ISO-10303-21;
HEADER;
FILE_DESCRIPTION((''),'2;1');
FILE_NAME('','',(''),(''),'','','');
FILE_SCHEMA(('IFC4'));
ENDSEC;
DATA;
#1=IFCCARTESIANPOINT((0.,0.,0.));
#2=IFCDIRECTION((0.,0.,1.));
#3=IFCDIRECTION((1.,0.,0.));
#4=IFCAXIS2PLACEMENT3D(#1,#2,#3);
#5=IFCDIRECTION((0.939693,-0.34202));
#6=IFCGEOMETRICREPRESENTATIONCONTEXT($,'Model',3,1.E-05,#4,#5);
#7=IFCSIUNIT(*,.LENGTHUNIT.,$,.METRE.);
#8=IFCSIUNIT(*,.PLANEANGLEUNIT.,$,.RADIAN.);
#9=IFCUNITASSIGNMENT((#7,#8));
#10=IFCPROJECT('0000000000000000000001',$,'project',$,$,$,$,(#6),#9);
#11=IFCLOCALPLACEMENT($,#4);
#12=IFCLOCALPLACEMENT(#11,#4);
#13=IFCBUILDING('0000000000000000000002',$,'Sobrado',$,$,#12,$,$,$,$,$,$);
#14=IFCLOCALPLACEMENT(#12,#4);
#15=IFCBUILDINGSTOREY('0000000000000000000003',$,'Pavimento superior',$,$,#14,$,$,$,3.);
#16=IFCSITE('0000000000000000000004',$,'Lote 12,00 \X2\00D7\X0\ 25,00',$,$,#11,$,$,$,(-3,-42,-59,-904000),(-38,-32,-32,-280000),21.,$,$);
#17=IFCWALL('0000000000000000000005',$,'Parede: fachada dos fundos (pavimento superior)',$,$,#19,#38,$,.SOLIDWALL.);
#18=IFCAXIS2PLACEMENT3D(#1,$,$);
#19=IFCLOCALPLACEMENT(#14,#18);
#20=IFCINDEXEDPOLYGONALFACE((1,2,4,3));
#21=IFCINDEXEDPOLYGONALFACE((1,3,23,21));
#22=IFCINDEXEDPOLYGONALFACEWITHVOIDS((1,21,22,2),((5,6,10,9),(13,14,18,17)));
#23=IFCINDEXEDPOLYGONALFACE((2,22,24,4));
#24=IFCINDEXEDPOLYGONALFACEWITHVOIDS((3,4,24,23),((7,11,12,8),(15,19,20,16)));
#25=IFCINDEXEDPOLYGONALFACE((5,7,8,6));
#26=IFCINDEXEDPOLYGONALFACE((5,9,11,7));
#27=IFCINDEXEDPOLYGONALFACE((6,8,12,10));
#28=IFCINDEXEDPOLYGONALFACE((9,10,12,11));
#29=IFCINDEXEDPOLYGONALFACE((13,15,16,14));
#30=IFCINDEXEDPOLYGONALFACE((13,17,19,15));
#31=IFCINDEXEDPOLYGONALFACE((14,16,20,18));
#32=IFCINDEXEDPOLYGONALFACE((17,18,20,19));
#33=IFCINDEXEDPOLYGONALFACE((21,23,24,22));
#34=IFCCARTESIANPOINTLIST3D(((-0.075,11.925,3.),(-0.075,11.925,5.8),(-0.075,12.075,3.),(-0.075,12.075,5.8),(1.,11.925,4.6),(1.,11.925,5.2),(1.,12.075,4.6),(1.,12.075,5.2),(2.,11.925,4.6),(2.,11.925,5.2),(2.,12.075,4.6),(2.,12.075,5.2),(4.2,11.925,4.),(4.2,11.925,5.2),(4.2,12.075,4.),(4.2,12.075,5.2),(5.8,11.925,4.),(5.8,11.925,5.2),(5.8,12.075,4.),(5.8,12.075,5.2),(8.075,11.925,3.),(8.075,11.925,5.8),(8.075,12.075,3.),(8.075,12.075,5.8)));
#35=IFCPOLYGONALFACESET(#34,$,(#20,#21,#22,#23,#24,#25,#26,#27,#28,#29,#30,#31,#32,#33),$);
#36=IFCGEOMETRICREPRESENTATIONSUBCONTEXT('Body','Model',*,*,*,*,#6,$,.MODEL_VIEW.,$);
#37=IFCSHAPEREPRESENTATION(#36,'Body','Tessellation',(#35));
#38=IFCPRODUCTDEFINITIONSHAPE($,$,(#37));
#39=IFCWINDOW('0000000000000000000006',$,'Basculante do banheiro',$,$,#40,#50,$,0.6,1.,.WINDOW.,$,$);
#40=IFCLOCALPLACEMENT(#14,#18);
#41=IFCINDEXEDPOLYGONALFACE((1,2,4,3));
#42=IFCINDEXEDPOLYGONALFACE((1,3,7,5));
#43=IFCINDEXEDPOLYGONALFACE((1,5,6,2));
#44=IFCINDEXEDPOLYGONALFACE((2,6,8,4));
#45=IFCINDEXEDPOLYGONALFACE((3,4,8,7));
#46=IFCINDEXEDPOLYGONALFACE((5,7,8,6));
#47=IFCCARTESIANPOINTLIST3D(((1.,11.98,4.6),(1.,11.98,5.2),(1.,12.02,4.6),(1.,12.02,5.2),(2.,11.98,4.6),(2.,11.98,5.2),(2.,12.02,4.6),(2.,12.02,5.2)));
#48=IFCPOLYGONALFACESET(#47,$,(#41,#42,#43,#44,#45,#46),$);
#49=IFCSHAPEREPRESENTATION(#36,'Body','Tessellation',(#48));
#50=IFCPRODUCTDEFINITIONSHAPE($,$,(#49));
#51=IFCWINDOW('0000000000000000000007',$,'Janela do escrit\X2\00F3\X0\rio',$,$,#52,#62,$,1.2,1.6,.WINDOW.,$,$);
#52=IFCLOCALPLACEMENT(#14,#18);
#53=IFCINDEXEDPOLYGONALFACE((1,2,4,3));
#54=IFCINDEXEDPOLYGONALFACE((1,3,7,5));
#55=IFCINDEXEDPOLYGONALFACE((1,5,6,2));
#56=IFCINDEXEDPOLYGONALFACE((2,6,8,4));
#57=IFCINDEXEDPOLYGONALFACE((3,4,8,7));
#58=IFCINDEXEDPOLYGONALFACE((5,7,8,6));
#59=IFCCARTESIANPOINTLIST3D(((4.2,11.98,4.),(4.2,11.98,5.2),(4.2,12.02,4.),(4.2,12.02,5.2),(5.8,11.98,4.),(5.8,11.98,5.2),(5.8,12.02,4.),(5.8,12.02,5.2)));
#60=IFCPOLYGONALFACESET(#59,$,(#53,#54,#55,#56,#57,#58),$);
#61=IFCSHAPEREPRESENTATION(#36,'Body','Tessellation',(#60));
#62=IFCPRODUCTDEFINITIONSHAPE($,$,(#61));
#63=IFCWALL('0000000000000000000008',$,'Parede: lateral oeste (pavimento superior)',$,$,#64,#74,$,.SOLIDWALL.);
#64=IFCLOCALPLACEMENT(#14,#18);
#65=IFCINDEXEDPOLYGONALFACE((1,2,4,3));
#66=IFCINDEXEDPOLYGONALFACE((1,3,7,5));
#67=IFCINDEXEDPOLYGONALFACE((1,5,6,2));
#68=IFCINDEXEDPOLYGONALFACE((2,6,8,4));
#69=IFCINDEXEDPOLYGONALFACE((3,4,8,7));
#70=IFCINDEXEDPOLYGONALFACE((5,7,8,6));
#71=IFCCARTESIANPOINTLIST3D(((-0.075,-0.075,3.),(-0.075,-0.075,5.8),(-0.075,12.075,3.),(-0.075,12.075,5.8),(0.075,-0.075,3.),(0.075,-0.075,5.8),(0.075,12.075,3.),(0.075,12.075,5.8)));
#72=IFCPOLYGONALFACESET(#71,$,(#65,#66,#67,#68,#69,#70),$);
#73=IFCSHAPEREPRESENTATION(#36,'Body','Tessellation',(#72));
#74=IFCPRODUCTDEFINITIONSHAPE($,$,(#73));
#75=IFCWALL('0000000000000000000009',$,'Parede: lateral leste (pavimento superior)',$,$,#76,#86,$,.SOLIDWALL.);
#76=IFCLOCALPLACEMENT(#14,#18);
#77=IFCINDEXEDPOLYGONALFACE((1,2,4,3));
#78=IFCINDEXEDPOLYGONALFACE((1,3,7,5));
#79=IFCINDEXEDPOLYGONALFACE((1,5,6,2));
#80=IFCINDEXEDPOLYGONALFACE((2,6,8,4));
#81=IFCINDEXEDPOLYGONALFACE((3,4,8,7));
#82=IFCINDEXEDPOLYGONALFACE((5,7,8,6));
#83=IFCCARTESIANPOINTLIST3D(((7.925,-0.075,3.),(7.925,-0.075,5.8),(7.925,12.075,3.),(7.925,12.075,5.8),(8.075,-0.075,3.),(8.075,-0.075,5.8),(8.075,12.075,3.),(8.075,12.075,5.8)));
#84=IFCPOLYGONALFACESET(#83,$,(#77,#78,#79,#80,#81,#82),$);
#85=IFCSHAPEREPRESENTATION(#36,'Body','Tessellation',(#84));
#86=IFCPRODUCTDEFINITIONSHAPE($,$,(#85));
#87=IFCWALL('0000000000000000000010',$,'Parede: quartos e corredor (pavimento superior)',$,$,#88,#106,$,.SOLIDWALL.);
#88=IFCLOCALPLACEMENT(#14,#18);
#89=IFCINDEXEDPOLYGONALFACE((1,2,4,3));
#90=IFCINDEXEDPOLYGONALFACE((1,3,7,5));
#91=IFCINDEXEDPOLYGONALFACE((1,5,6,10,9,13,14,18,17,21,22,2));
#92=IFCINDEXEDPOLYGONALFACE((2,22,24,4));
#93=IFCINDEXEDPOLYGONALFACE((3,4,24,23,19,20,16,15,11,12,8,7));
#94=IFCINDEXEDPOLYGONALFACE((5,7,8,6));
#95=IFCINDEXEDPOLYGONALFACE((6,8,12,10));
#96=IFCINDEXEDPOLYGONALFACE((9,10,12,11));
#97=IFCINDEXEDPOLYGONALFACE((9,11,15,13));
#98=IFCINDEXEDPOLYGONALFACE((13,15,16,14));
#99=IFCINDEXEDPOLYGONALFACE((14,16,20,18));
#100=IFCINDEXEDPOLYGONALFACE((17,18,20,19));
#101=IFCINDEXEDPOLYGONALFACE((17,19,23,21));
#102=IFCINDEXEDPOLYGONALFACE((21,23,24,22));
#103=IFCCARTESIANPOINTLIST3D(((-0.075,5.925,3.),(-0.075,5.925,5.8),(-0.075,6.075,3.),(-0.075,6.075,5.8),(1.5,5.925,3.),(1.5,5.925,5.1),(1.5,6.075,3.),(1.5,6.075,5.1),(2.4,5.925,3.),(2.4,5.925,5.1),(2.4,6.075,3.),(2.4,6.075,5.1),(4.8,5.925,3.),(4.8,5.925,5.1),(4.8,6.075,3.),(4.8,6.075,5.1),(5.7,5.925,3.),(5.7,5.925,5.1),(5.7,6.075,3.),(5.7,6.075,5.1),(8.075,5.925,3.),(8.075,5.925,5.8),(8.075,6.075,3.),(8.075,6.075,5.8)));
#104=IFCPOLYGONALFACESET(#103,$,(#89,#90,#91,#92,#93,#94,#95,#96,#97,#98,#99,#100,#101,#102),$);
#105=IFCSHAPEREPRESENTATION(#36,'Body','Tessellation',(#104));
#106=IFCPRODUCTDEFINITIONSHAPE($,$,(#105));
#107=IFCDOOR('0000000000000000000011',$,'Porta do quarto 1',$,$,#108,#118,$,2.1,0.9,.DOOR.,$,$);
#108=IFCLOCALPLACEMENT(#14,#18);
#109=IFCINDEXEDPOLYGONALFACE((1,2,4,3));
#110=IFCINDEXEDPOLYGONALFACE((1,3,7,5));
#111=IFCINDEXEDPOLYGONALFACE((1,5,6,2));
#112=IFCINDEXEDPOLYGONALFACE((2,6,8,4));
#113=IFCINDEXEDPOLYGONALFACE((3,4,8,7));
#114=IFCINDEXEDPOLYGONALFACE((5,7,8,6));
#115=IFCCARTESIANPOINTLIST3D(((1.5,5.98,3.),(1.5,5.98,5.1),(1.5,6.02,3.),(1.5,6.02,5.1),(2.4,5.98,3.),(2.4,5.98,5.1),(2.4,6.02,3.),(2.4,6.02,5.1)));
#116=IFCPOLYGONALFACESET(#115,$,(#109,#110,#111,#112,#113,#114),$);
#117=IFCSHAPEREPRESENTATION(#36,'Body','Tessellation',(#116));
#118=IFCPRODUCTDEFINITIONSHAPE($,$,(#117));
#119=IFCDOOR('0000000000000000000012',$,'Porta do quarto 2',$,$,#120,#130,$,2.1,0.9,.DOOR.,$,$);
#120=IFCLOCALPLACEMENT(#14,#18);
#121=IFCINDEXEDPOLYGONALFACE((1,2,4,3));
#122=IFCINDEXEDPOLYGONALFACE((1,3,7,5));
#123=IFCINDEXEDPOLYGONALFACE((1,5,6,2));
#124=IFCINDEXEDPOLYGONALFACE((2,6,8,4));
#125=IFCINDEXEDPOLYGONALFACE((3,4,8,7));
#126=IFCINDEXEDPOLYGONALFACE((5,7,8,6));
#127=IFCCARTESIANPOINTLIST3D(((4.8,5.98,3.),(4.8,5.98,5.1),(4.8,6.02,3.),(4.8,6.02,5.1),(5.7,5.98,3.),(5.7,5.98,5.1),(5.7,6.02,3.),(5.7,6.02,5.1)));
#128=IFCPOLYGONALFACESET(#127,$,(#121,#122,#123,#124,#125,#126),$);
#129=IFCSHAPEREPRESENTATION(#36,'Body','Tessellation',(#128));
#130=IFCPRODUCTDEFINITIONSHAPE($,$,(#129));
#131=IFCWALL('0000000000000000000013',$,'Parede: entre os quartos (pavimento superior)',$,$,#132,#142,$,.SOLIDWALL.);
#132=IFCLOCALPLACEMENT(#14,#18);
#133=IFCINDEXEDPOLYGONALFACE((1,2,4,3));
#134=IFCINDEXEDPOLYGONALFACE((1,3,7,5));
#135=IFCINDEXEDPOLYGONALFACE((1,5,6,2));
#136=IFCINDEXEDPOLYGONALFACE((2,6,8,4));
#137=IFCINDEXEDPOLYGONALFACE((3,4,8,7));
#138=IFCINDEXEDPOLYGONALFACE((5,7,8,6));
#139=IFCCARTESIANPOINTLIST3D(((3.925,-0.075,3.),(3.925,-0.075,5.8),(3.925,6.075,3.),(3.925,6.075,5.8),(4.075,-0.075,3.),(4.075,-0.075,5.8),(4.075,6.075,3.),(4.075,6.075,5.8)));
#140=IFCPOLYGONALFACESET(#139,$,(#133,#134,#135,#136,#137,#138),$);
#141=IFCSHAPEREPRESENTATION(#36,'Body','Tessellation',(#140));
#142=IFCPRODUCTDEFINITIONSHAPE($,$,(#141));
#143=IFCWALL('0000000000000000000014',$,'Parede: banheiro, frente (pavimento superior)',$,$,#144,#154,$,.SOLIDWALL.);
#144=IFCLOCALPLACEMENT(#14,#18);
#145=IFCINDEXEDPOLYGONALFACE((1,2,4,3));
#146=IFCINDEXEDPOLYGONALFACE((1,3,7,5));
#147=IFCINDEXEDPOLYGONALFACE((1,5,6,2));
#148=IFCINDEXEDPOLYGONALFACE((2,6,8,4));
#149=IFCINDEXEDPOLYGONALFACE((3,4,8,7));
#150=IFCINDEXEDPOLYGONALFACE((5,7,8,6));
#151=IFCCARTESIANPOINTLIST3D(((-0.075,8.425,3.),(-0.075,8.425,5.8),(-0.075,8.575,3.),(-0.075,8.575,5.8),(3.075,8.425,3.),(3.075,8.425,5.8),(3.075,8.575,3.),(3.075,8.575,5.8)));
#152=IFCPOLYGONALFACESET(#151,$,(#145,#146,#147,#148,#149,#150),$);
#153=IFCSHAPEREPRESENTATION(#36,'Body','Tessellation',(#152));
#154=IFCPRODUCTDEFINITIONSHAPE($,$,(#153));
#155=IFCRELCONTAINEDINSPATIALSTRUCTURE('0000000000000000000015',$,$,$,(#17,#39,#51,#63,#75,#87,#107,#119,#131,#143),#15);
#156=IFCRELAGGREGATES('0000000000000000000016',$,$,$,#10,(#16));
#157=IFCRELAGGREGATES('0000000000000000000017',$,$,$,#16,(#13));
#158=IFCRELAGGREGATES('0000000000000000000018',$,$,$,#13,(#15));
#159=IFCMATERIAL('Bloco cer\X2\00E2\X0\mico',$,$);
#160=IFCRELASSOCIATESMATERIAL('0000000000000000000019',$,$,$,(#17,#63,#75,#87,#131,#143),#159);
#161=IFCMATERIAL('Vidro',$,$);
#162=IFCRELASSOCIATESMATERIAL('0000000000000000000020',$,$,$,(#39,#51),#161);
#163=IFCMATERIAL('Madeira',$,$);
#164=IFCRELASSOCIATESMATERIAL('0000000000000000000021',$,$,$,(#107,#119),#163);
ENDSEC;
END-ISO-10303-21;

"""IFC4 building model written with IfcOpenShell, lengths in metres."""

from ifc_helpers import new_model, si_unit, direction, frame, origin_with_axes, place, context, subcontext, project, spatial, line, indexed_curve, outline, extrude, material, element, fill, save


model = new_model("IFC4")

# Units and contexts
model_context = context("Model", 3, precision=1e-05, world=origin_with_axes(), true_north=direction((0.939693, -0.34202)))
body_context = subcontext(model_context, "Body", "Model", "MODEL_VIEW")
ifc_project = project(units=[si_unit("LENGTHUNIT", "METRE"), si_unit("PLANEANGLEUNIT", "RADIAN")], contexts=[model_context])

# Site, building, storey
site_placement = place(None, origin_with_axes())
site = spatial("IfcSite", under=ifc_project, at=site_placement, Name="Lote 12,00 × 25,00", RefLatitude=(-3, -42, -59, -904000), RefLongitude=(-38, -32, -32, -280000), RefElevation=21.0)
building_placement = place(site_placement, origin_with_axes())
building = spatial("IfcBuilding", under=site, at=building_placement, Name="Sobrado")
storey_placement = place(building_placement, origin_with_axes())
storey = spatial("IfcBuildingStorey", under=building, at=storey_placement, Name="Pavimento superior", Elevation=3.0)

# Shared definitions
ifc_material_1 = material(Name="Concreto armado")

# Wall, openings, windows
ifc_material_2 = material(Name="Bloco cerâmico")
ifc_material_3 = material(Name="Vidro")
wall_1_placement = place(storey_placement, origin_with_axes())
wall_1 = element("IfcWall", 1, at=wall_1_placement, inside=storey, material=ifc_material_2, Name="Parede: fachada dos fundos (pavimento superior)", PredefinedType="SOLIDWALL", context=body_context, shape_type="SweptSolid", body=[
    extrude(outline(indexed_curve([(-0.075, 11.925), (8.075, 11.925), (8.075, 12.075), (-0.075, 12.075)], segments=[line(1, 2, 3, 4, 1)])), frame((0.0, 0.0, 3.0), z_axis=(0.0, 0.0, 1.0), x_axis=(1.0, 0.0, 0.0)), (0.0, 0.0, 1.0), 2.8),
])
opening_1_placement = place(wall_1_placement, origin_with_axes())
opening_1 = element("IfcOpeningElement", 2, at=opening_1_placement, cuts=wall_1, material=ifc_material_1, PredefinedType="OPENING", context=body_context, shape_type="SweptSolid", body=[
    extrude(outline(indexed_curve([(1.0, 11.875), (2.0, 11.875), (2.0, 12.125), (1.0, 12.125)], segments=[line(1, 2, 3, 4, 1)])), frame((0.0, 0.0, 4.6), z_axis=(0.0, 0.0, 1.0), x_axis=(1.0, 0.0, 0.0)), (0.0, 0.0, 1.0), 0.6),
])
opening_2_placement = place(wall_1_placement, origin_with_axes())
opening_2 = element("IfcOpeningElement", 3, at=opening_2_placement, cuts=wall_1, material=ifc_material_1, PredefinedType="OPENING", context=body_context, shape_type="SweptSolid", body=[
    extrude(outline(indexed_curve([(4.2, 11.875), (5.8, 11.875), (5.8, 12.125), (4.2, 12.125)], segments=[line(1, 2, 3, 4, 1)])), frame((0.0, 0.0, 4.0), z_axis=(0.0, 0.0, 1.0), x_axis=(1.0, 0.0, 0.0)), (0.0, 0.0, 1.0), 1.2),
])
window_1_placement = place(storey_placement, origin_with_axes())
window_1 = element("IfcWindow", 4, at=window_1_placement, inside=storey, material=ifc_material_3, Name="Basculante do banheiro", OverallHeight=0.6, OverallWidth=1.0, PredefinedType="WINDOW", context=body_context, shape_type="SweptSolid", body=[
    extrude(outline(indexed_curve([(1.0, 11.98), (2.0, 11.98), (2.0, 12.02), (1.0, 12.02)], segments=[line(1, 2, 3, 4, 1)])), frame((0.0, 0.0, 4.6), z_axis=(0.0, 0.0, 1.0), x_axis=(1.0, 0.0, 0.0)), (0.0, 0.0, 1.0), 0.6),
])
fill(opening_1, window_1)
window_2_placement = place(storey_placement, origin_with_axes())
window_2 = element("IfcWindow", 5, at=window_2_placement, inside=storey, material=ifc_material_3, Name="Janela do escritório", OverallHeight=1.2, OverallWidth=1.6, PredefinedType="WINDOW", context=body_context, shape_type="SweptSolid", body=[
    extrude(outline(indexed_curve([(4.2, 11.98), (5.8, 11.98), (5.8, 12.02), (4.2, 12.02)], segments=[line(1, 2, 3, 4, 1)])), frame((0.0, 0.0, 4.0), z_axis=(0.0, 0.0, 1.0), x_axis=(1.0, 0.0, 0.0)), (0.0, 0.0, 1.0), 1.2),
])
fill(opening_2, window_2)

# Walls
wall_2_placement = place(storey_placement, origin_with_axes())
element("IfcWall", 6, at=wall_2_placement, inside=storey, material=ifc_material_2, Name="Parede: lateral oeste (pavimento superior)", PredefinedType="SOLIDWALL", context=body_context, shape_type="SweptSolid", body=[
    extrude(outline(indexed_curve([(-0.075, -0.075), (0.075, -0.075), (0.075, 12.075), (-0.075, 12.075)], segments=[line(1, 2, 3, 4, 1)])), frame((0.0, 0.0, 3.0), z_axis=(0.0, 0.0, 1.0), x_axis=(1.0, 0.0, 0.0)), (0.0, 0.0, 1.0), 2.8),
])
wall_3_placement = place(storey_placement, origin_with_axes())
element("IfcWall", 7, at=wall_3_placement, inside=storey, material=ifc_material_2, Name="Parede: lateral leste (pavimento superior)", PredefinedType="SOLIDWALL", context=body_context, shape_type="SweptSolid", body=[
    extrude(outline(indexed_curve([(7.925, -0.075), (8.075, -0.075), (8.075, 12.075), (7.925, 12.075)], segments=[line(1, 2, 3, 4, 1)])), frame((0.0, 0.0, 3.0), z_axis=(0.0, 0.0, 1.0), x_axis=(1.0, 0.0, 0.0)), (0.0, 0.0, 1.0), 2.8),
])

# Wall, openings, doors
wall_4_placement = place(storey_placement, origin_with_axes())
wall_4 = element("IfcWall", 8, at=wall_4_placement, inside=storey, material=ifc_material_2, Name="Parede: quartos e corredor (pavimento superior)", PredefinedType="SOLIDWALL", context=body_context, shape_type="SweptSolid", body=[
    extrude(outline(indexed_curve([(-0.075, 5.925), (8.075, 5.925), (8.075, 6.075), (-0.075, 6.075)], segments=[line(1, 2, 3, 4, 1)])), frame((0.0, 0.0, 3.0), z_axis=(0.0, 0.0, 1.0), x_axis=(1.0, 0.0, 0.0)), (0.0, 0.0, 1.0), 2.8),
])
opening_3_placement = place(wall_4_placement, origin_with_axes())
opening_3 = element("IfcOpeningElement", 9, at=opening_3_placement, cuts=wall_4, material=ifc_material_1, PredefinedType="OPENING", context=body_context, shape_type="SweptSolid", body=[
    extrude(outline(indexed_curve([(1.5, 5.875), (2.4, 5.875), (2.4, 6.125), (1.5, 6.125)], segments=[line(1, 2, 3, 4, 1)])), frame((0.0, 0.0, 3.0), z_axis=(0.0, 0.0, 1.0), x_axis=(1.0, 0.0, 0.0)), (0.0, 0.0, 1.0), 2.1),
])
opening_4_placement = place(wall_4_placement, origin_with_axes())
opening_4 = element("IfcOpeningElement", 10, at=opening_4_placement, cuts=wall_4, material=ifc_material_1, PredefinedType="OPENING", context=body_context, shape_type="SweptSolid", body=[
    extrude(outline(indexed_curve([(4.8, 5.875), (5.7, 5.875), (5.7, 6.125), (4.8, 6.125)], segments=[line(1, 2, 3, 4, 1)])), frame((0.0, 0.0, 3.0), z_axis=(0.0, 0.0, 1.0), x_axis=(1.0, 0.0, 0.0)), (0.0, 0.0, 1.0), 2.1),
])
ifc_material_4 = material(Name="Madeira")
door_1_placement = place(storey_placement, origin_with_axes())
door_1 = element("IfcDoor", 11, at=door_1_placement, inside=storey, material=ifc_material_4, Name="Porta do quarto 1", OverallHeight=2.1, OverallWidth=0.9, PredefinedType="DOOR", context=body_context, shape_type="SweptSolid", body=[
    extrude(outline(indexed_curve([(1.5, 5.98), (2.4, 5.98), (2.4, 6.02), (1.5, 6.02)], segments=[line(1, 2, 3, 4, 1)])), frame((0.0, 0.0, 3.0), z_axis=(0.0, 0.0, 1.0), x_axis=(1.0, 0.0, 0.0)), (0.0, 0.0, 1.0), 2.1),
])
fill(opening_3, door_1)
door_2_placement = place(storey_placement, origin_with_axes())
door_2 = element("IfcDoor", 12, at=door_2_placement, inside=storey, material=ifc_material_4, Name="Porta do quarto 2", OverallHeight=2.1, OverallWidth=0.9, PredefinedType="DOOR", context=body_context, shape_type="SweptSolid", body=[
    extrude(outline(indexed_curve([(4.8, 5.98), (5.7, 5.98), (5.7, 6.02), (4.8, 6.02)], segments=[line(1, 2, 3, 4, 1)])), frame((0.0, 0.0, 3.0), z_axis=(0.0, 0.0, 1.0), x_axis=(1.0, 0.0, 0.0)), (0.0, 0.0, 1.0), 2.1),
])
fill(opening_4, door_2)

# Walls
wall_5_placement = place(storey_placement, origin_with_axes())
element("IfcWall", 13, at=wall_5_placement, inside=storey, material=ifc_material_2, Name="Parede: entre os quartos (pavimento superior)", PredefinedType="SOLIDWALL", context=body_context, shape_type="SweptSolid", body=[
    extrude(outline(indexed_curve([(3.925, -0.075), (4.075, -0.075), (4.075, 6.075), (3.925, 6.075)], segments=[line(1, 2, 3, 4, 1)])), frame((0.0, 0.0, 3.0), z_axis=(0.0, 0.0, 1.0), x_axis=(1.0, 0.0, 0.0)), (0.0, 0.0, 1.0), 2.8),
])
wall_6_placement = place(storey_placement, origin_with_axes())
element("IfcWall", 14, at=wall_6_placement, inside=storey, material=ifc_material_2, Name="Parede: banheiro, frente (pavimento superior)", PredefinedType="SOLIDWALL", context=body_context, shape_type="SweptSolid", body=[
    extrude(outline(indexed_curve([(-0.075, 8.425), (3.075, 8.425), (3.075, 8.575), (-0.075, 8.575)], segments=[line(1, 2, 3, 4, 1)])), frame((0.0, 0.0, 3.0), z_axis=(0.0, 0.0, 1.0), x_axis=(1.0, 0.0, 0.0)), (0.0, 0.0, 1.0), 2.8),
])

save(model, "model.ifc")
